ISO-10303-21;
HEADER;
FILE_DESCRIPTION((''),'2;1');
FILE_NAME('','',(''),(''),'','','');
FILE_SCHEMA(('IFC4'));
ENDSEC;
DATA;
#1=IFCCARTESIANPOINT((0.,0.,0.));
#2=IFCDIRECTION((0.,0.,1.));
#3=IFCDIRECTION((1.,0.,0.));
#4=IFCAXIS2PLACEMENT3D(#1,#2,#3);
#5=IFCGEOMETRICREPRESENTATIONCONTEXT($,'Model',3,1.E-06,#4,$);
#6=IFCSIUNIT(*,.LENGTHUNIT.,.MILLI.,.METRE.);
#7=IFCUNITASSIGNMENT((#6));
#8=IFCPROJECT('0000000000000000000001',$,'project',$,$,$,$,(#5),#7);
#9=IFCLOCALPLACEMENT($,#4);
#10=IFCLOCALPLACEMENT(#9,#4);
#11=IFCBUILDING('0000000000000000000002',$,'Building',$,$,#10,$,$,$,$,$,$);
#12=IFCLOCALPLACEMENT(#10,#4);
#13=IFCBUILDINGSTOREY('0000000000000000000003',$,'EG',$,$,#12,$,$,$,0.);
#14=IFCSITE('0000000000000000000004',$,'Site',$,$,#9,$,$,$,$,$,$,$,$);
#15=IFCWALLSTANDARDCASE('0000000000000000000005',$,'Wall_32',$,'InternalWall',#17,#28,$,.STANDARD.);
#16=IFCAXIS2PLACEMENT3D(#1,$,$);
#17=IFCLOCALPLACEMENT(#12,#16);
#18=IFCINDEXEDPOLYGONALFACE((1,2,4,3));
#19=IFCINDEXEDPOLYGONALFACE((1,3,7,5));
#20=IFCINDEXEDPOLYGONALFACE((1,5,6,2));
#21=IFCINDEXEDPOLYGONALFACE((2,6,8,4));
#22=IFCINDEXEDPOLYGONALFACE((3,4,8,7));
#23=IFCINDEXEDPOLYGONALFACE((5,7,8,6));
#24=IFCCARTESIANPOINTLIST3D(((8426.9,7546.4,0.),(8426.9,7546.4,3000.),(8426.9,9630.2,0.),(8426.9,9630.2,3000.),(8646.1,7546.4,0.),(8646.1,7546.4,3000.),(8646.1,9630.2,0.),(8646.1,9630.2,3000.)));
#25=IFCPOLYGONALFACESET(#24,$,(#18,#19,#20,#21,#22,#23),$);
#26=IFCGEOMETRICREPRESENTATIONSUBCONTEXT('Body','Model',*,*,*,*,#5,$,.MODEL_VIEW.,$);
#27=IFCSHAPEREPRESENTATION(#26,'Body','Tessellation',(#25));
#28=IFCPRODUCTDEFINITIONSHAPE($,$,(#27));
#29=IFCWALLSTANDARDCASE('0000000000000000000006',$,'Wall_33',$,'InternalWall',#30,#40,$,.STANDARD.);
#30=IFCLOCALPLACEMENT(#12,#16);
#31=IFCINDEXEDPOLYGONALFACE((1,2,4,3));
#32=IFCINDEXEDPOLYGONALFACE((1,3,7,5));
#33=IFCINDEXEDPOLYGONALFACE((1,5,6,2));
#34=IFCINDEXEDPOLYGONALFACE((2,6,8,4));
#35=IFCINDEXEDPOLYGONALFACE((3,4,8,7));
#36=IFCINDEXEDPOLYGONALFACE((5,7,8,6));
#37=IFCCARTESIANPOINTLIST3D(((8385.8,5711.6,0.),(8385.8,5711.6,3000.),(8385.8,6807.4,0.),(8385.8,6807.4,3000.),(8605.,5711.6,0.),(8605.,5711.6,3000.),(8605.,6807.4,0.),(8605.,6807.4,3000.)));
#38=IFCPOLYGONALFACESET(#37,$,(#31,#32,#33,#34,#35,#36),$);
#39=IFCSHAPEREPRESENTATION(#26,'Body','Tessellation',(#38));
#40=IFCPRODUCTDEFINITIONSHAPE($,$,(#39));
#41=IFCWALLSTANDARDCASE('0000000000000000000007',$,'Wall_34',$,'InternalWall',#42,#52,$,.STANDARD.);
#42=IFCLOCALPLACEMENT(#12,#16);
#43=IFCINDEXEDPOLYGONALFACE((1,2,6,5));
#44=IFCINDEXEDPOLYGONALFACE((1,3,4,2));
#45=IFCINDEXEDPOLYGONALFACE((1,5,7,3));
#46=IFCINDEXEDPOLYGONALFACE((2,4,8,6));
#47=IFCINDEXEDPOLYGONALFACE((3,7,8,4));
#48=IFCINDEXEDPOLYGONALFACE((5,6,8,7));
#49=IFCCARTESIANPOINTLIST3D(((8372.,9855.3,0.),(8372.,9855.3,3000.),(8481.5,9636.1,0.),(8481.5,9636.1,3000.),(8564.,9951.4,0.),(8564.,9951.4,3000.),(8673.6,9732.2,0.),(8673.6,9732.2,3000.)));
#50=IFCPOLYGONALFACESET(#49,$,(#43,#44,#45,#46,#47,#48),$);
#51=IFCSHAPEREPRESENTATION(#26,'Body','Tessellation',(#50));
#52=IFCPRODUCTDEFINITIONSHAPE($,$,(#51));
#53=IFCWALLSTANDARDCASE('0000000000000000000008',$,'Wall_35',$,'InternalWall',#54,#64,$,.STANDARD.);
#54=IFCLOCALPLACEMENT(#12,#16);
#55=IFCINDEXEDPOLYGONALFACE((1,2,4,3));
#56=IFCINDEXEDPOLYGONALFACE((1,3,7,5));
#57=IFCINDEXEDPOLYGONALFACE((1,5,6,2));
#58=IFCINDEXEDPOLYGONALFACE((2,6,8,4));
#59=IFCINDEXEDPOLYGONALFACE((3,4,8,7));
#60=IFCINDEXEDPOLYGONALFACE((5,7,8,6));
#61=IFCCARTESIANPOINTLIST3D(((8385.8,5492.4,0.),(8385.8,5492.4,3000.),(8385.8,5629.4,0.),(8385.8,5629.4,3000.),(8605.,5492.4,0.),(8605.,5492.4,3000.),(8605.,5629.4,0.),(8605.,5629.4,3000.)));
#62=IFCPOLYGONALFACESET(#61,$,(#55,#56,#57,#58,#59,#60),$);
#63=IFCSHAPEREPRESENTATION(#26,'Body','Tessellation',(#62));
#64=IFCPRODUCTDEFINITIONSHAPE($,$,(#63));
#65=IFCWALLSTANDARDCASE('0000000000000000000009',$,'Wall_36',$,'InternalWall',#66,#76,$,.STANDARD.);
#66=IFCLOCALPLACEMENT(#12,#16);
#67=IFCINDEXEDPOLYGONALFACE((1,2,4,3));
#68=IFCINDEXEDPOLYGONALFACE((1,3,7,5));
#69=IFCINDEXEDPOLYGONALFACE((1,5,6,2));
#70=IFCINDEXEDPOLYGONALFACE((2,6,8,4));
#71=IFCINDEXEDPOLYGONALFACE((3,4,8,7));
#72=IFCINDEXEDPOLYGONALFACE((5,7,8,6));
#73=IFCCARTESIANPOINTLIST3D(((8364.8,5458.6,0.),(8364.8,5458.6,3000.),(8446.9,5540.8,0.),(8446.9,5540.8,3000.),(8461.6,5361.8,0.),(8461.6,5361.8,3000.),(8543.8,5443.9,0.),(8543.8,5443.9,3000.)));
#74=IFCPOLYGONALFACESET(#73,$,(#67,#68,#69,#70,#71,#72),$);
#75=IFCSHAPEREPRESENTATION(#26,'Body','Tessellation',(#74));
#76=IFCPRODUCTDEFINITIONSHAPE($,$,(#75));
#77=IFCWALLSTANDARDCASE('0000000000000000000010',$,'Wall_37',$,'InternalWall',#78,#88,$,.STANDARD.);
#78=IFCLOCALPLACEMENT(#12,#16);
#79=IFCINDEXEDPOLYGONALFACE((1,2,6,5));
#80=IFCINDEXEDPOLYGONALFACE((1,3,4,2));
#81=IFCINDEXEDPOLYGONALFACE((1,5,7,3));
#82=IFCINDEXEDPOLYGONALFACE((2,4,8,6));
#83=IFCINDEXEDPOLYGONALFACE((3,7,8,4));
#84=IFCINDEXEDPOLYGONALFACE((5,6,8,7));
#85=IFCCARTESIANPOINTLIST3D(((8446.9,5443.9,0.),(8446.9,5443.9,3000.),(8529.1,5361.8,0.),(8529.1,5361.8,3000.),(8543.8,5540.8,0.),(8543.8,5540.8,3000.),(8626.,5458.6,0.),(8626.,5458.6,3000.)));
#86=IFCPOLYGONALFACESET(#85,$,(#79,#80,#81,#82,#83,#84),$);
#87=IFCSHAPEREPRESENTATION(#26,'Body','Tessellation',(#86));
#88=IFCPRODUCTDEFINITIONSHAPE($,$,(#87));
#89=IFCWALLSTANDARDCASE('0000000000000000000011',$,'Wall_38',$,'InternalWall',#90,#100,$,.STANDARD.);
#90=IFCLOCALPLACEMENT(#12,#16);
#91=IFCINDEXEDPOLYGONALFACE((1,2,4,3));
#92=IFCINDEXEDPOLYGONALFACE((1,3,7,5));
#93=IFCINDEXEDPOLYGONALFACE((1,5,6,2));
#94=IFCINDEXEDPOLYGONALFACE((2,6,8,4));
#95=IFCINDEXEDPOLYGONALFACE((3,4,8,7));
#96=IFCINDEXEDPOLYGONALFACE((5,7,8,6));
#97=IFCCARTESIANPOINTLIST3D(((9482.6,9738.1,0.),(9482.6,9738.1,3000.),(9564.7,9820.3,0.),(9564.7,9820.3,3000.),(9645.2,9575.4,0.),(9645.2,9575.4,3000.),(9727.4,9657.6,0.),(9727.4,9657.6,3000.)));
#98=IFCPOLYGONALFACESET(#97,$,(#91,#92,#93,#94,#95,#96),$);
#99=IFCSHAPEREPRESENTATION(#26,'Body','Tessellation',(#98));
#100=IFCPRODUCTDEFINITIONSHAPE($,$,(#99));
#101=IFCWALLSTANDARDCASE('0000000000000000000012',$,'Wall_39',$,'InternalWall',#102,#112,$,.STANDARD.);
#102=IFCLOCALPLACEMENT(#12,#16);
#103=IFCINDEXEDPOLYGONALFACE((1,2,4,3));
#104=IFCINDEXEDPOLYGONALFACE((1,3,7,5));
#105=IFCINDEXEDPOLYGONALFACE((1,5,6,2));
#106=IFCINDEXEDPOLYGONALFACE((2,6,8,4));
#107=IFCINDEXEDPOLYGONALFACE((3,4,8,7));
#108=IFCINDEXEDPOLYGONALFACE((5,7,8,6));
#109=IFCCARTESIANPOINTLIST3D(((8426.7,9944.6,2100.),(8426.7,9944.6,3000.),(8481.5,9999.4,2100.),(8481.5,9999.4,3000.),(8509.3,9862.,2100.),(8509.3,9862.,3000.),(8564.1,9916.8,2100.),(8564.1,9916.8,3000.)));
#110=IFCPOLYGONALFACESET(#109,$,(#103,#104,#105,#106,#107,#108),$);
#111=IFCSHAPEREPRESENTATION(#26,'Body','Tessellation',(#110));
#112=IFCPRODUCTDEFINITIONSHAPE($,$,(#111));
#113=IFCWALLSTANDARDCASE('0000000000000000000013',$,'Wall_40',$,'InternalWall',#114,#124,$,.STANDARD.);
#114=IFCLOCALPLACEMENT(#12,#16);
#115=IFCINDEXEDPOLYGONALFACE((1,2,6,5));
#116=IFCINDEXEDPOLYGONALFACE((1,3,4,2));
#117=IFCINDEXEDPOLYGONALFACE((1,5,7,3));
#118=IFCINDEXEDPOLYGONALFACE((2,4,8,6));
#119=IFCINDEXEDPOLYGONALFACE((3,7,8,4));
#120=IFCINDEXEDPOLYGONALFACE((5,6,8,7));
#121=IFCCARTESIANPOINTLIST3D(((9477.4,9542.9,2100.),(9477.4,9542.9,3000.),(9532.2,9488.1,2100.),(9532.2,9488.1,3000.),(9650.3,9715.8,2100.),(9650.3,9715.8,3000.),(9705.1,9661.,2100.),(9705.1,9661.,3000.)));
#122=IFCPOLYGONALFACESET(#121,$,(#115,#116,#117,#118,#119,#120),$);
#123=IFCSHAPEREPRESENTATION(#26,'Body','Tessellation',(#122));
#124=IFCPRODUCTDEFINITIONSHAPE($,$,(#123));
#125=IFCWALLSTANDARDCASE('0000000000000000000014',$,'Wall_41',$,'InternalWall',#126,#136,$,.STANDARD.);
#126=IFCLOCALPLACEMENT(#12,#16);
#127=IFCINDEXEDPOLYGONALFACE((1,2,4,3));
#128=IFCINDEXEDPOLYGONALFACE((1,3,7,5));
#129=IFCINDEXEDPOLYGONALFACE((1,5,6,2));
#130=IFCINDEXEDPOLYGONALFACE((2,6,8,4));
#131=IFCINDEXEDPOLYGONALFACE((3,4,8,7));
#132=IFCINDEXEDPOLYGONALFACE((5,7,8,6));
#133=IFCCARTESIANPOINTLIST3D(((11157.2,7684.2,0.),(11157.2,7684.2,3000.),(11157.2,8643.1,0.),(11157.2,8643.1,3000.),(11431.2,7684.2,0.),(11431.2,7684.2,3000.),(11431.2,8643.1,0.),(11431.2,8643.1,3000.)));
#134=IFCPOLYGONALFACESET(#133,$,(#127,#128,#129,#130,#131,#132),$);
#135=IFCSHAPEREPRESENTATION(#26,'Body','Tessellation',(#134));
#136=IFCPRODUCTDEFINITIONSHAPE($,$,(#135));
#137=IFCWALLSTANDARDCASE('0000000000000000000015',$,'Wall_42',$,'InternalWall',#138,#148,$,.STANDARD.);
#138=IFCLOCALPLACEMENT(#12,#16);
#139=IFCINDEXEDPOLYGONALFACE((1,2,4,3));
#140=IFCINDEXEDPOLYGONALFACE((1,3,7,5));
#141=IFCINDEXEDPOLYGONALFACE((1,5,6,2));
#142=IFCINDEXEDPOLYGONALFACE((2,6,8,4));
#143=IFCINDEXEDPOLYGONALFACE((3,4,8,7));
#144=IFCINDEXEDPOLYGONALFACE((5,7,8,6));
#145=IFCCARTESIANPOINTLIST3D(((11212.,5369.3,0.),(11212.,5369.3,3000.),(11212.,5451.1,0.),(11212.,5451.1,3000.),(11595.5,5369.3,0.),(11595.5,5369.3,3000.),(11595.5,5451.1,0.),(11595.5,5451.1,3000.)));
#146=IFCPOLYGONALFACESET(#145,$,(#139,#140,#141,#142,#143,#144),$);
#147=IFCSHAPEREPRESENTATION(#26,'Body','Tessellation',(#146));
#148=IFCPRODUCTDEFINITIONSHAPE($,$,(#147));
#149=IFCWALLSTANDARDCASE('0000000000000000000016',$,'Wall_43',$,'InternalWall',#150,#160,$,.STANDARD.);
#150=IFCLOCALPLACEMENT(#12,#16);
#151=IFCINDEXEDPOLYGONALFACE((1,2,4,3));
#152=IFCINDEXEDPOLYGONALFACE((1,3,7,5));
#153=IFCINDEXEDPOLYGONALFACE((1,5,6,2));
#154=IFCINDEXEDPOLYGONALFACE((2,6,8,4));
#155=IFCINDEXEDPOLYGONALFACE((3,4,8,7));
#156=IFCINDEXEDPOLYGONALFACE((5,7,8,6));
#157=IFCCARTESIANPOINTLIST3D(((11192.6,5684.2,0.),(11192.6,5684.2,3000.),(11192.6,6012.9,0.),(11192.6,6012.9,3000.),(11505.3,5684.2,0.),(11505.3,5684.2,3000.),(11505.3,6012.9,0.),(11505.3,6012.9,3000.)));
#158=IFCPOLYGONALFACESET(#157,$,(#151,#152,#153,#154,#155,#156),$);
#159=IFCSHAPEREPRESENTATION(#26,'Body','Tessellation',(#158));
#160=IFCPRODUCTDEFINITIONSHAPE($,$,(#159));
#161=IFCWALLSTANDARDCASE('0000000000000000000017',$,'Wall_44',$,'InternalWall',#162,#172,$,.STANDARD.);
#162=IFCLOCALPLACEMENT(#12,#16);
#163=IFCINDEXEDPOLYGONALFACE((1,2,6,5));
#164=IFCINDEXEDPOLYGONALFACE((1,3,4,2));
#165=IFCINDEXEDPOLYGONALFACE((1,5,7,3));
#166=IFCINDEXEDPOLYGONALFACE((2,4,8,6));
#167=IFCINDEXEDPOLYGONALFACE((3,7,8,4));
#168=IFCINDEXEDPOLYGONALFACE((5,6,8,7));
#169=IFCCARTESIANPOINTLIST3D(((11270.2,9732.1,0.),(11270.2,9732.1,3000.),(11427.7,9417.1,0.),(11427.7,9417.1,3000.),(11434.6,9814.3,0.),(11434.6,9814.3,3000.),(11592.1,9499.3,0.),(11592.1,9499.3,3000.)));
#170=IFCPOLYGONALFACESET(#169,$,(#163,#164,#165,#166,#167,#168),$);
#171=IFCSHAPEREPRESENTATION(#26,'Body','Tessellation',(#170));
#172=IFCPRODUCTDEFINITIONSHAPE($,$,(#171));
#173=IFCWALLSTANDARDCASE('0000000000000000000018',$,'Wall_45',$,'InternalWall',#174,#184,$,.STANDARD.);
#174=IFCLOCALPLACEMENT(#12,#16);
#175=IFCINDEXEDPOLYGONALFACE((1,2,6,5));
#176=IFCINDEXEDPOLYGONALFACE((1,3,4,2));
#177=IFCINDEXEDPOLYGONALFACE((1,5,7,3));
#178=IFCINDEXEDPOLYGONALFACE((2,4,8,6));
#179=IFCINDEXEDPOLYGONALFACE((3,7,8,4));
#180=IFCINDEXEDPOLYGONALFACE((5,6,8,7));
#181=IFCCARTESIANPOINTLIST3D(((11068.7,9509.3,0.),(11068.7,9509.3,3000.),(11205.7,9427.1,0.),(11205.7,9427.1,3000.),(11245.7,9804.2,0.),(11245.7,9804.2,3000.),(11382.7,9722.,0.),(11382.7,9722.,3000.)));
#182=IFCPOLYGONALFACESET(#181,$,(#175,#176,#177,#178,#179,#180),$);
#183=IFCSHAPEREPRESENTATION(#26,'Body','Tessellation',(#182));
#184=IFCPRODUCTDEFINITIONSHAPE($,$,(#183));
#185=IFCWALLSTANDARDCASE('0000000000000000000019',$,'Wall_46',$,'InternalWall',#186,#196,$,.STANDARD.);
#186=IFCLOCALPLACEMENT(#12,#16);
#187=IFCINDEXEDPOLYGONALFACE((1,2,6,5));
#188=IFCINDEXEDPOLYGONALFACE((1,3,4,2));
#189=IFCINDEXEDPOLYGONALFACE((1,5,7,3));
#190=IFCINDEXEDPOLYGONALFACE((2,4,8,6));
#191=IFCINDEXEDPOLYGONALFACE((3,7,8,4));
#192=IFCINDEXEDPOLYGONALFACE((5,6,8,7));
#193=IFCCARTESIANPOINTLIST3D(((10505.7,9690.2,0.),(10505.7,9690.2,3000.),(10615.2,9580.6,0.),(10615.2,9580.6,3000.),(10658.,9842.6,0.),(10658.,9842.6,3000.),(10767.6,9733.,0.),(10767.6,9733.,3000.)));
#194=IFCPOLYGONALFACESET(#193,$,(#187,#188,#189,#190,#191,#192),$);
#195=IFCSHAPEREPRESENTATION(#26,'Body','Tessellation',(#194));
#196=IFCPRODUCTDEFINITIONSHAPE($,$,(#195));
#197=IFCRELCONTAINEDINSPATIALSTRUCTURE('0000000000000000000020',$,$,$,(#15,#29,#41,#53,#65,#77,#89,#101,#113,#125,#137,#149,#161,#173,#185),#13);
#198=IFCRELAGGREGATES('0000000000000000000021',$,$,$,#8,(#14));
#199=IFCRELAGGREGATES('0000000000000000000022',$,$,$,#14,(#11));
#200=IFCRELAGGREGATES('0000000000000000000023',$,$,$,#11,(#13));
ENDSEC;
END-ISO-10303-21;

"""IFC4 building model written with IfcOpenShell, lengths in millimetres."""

from ifc_helpers import new_model, si_unit, frame, origin_with_axes, place, context, subcontext, project, spatial, rectangle, extrude, element, save


model = new_model("IFC4")

# Units and contexts
model_context = context("Model", 3, precision=1e-06, world=origin_with_axes())
body_context = subcontext(model_context, "Body", "Model", "MODEL_VIEW")
ifc_project = project(units=[si_unit("LENGTHUNIT", "METRE", prefix="MILLI")], contexts=[model_context])

# Site, building, storey
site_placement = place(None, origin_with_axes())
site = spatial("IfcSite", under=ifc_project, at=site_placement, Name="Site")
building_placement = place(site_placement, origin_with_axes())
building = spatial("IfcBuilding", under=site, at=building_placement, Name="Building")
storey_placement = place(building_placement, origin_with_axes())
storey = spatial("IfcBuildingStorey", under=building, at=storey_placement, Name="EG", Elevation=0.0)

# Walls
wall_1_placement = place(storey_placement, origin_with_axes())
element("IfcWallStandardCase", 1, at=wall_1_placement, inside=storey, Name="Wall_32", ObjectType="InternalWall", PredefinedType="STANDARD", context=body_context, shape_type="SweptSolid", body=[
    extrude(rectangle(XDim=2083.8, YDim=219.2), frame((8536.5, 8588.3, 0.0), z_axis=(0.0, 0.0, 1.0), x_axis=(0.0, 1.0, 0.0)), (0.0, 0.0, 1.0), 3000.0),
])
wall_2_placement = place(storey_placement, origin_with_axes())
element("IfcWallStandardCase", 2, at=wall_2_placement, inside=storey, Name="Wall_33", ObjectType="InternalWall", PredefinedType="STANDARD", context=body_context, shape_type="SweptSolid", body=[
    extrude(rectangle(XDim=1095.9, YDim=219.2), frame((8495.4, 6259.5, 0.0), z_axis=(0.0, 0.0, 1.0), x_axis=(0.0, -1.0, 0.0)), (0.0, 0.0, 1.0), 3000.0),
])
wall_3_placement = place(storey_placement, origin_with_axes())
element("IfcWallStandardCase", 3, at=wall_3_placement, inside=storey, Name="Wall_34", ObjectType="InternalWall", PredefinedType="STANDARD", context=body_context, shape_type="SweptSolid", body=[
    extrude(rectangle(XDim=245.0, YDim=214.7), frame((8522.8, 9793.8, 0.0), z_axis=(0.0, 0.0, 1.0), x_axis=(-0.447214, 0.894427, 0.0)), (0.0, 0.0, 1.0), 3000.0),
])
wall_4_placement = place(storey_placement, origin_with_axes())
element("IfcWallStandardCase", 4, at=wall_4_placement, inside=storey, Name="Wall_35", ObjectType="InternalWall", PredefinedType="STANDARD", context=body_context, shape_type="SweptSolid", body=[
    extrude(rectangle(XDim=137.0, YDim=219.2), frame((8495.4, 5560.9, 0.0), z_axis=(0.0, 0.0, 1.0), x_axis=(0.0, -1.0, 0.0)), (0.0, 0.0, 1.0), 3000.0),
])
wall_5_placement = place(storey_placement, origin_with_axes())
element("IfcWallStandardCase", 5, at=wall_5_placement, inside=storey, Name="Wall_36", ObjectType="InternalWall", PredefinedType="STANDARD", context=body_context, shape_type="SweptSolid", body=[
    extrude(rectangle(XDim=116.2, YDim=137.0), frame((8454.3, 5451.3, 0.0), z_axis=(0.0, 0.0, 1.0), x_axis=(-0.707107, -0.707107, 0.0)), (0.0, 0.0, 1.0), 3000.0),
])
wall_6_placement = place(storey_placement, origin_with_axes())
element("IfcWallStandardCase", 6, at=wall_6_placement, inside=storey, Name="Wall_37", ObjectType="InternalWall", PredefinedType="STANDARD", context=body_context, shape_type="SweptSolid", body=[
    extrude(rectangle(XDim=116.2, YDim=137.0), frame((8536.5, 5451.3, 0.0), z_axis=(0.0, 0.0, 1.0), x_axis=(0.707107, -0.707107, 0.0)), (0.0, 0.0, 1.0), 3000.0),
])
wall_7_placement = place(storey_placement, origin_with_axes())
element("IfcWallStandardCase", 7, at=wall_7_placement, inside=storey, Name="Wall_38", ObjectType="InternalWall", PredefinedType="STANDARD", context=body_context, shape_type="SweptSolid", body=[
    extrude(rectangle(XDim=116.2, YDim=230.0), frame((9605.0, 9697.9, 0.0), z_axis=(0.0, 0.0, 1.0), x_axis=(0.707107, 0.707107, 0.0)), (0.0, 0.0, 1.0), 3000.0),
])

# Walls, openings
wall_8_placement = place(storey_placement, origin_with_axes())
wall_8 = element("IfcWallStandardCase", 8, at=wall_8_placement, inside=storey, Name="Wall_39", ObjectType="InternalWall", PredefinedType="STANDARD", context=body_context, shape_type="SweptSolid", body=[
    extrude(rectangle(XDim=77.5, YDim=116.8), frame((8495.4, 9930.7, 0.0), z_axis=(0.0, 0.0, 1.0), x_axis=(0.707107, 0.707107, 0.0)), (0.0, 0.0, 1.0), 3000.0),
])
opening_1_placement = place(wall_8_placement, origin_with_axes())
element("IfcOpeningElement", 9, at=opening_1_placement, inside=storey, cuts=wall_8, context=body_context, shape_type="SweptSolid", body=[
    extrude(rectangle(XDim=450.0, YDim=116.8), frame((8495.4, 9930.7, 0.0), z_axis=(0.0, 0.0, 1.0), x_axis=(0.707107, 0.707107, 0.0)), (0.0, 0.0, 1.0), 2100.0),
])
wall_9_placement = place(storey_placement, origin_with_axes())
wall_9 = element("IfcWallStandardCase", 10, at=wall_9_placement, inside=storey, Name="Wall_40", ObjectType="InternalWall", PredefinedType="STANDARD", context=body_context, shape_type="SweptSolid", body=[
    extrude(rectangle(XDim=77.5, YDim=244.5), frame((9591.3, 9602.0, 0.0), z_axis=(0.0, 0.0, 1.0), x_axis=(0.707107, -0.707107, 0.0)), (0.0, 0.0, 1.0), 3000.0),
])
opening_2_placement = place(wall_9_placement, origin_with_axes())
element("IfcOpeningElement", 11, at=opening_2_placement, inside=storey, cuts=wall_9, context=body_context, shape_type="SweptSolid", body=[
    extrude(rectangle(XDim=450.0, YDim=244.5), frame((9591.3, 9602.0, 0.0), z_axis=(0.0, 0.0, 1.0), x_axis=(0.707107, -0.707107, 0.0)), (0.0, 0.0, 1.0), 2100.0),
])

# Walls
wall_10_placement = place(storey_placement, origin_with_axes())
element("IfcWallStandardCase", 12, at=wall_10_placement, inside=storey, Name="Wall_41", ObjectType="InternalWall", PredefinedType="STANDARD", context=body_context, shape_type="SweptSolid", body=[
    extrude(rectangle(XDim=958.9, YDim=274.0), frame((11294.2, 8163.6, 0.0), z_axis=(0.0, 0.0, 1.0), x_axis=(0.0, 1.0, 0.0)), (0.0, 0.0, 1.0), 3000.0),
])
wall_11_placement = place(storey_placement, origin_with_axes())
element("IfcWallStandardCase", 13, at=wall_11_placement, inside=storey, Name="Wall_42", ObjectType="InternalWall", PredefinedType="STANDARD", context=body_context, shape_type="SweptSolid", body=[
    extrude(rectangle(XDim=383.6, YDim=81.8), frame((11403.8, 5410.2, 0.0), z_axis=(0.0, 0.0, 1.0), x_axis=(1.0, 0.0, 0.0)), (0.0, 0.0, 1.0), 3000.0),
])
wall_12_placement = place(storey_placement, origin_with_axes())
element("IfcWallStandardCase", 14, at=wall_12_placement, inside=storey, Name="Wall_43", ObjectType="InternalWall", PredefinedType="STANDARD", context=body_context, shape_type="SweptSolid", body=[
    extrude(rectangle(XDim=328.8, YDim=312.7), frame((11349.0, 5848.5, 0.0), z_axis=(0.0, 0.0, 1.0), x_axis=(0.0, -1.0, 0.0)), (0.0, 0.0, 1.0), 3000.0),
])
wall_13_placement = place(storey_placement, origin_with_axes())
element("IfcWallStandardCase", 15, at=wall_13_placement, inside=storey, Name="Wall_44", ObjectType="InternalWall", PredefinedType="STANDARD", context=body_context, shape_type="SweptSolid", body=[
    extrude(rectangle(XDim=183.8, YDim=352.2), frame((11431.2, 9615.7, 0.0), z_axis=(0.0, 0.0, 1.0), x_axis=(0.894427, 0.447214, 0.0)), (0.0, 0.0, 1.0), 3000.0),
])
wall_14_placement = place(storey_placement, origin_with_axes())
element("IfcWallStandardCase", 16, at=wall_14_placement, inside=storey, Name="Wall_45", ObjectType="InternalWall", PredefinedType="STANDARD", context=body_context, shape_type="SweptSolid", body=[
    extrude(rectangle(XDim=159.8, YDim=343.9), frame((11225.7, 9615.7, 0.0), z_axis=(0.0, 0.0, 1.0), x_axis=(0.857493, -0.514496, 0.0)), (0.0, 0.0, 1.0), 3000.0),
])
wall_15_placement = place(storey_placement, origin_with_axes())
element("IfcWallStandardCase", 17, at=wall_15_placement, inside=storey, Name="Wall_46", ObjectType="InternalWall", PredefinedType="STANDARD", context=body_context, shape_type="SweptSolid", body=[
    extrude(rectangle(XDim=155.0, YDim=215.5), frame((10636.6, 9711.6, 0.0), z_axis=(0.0, 0.0, 1.0), x_axis=(-0.707107, 0.707107, 0.0)), (0.0, 0.0, 1.0), 3000.0),
])

save(model, "model.ifc")
